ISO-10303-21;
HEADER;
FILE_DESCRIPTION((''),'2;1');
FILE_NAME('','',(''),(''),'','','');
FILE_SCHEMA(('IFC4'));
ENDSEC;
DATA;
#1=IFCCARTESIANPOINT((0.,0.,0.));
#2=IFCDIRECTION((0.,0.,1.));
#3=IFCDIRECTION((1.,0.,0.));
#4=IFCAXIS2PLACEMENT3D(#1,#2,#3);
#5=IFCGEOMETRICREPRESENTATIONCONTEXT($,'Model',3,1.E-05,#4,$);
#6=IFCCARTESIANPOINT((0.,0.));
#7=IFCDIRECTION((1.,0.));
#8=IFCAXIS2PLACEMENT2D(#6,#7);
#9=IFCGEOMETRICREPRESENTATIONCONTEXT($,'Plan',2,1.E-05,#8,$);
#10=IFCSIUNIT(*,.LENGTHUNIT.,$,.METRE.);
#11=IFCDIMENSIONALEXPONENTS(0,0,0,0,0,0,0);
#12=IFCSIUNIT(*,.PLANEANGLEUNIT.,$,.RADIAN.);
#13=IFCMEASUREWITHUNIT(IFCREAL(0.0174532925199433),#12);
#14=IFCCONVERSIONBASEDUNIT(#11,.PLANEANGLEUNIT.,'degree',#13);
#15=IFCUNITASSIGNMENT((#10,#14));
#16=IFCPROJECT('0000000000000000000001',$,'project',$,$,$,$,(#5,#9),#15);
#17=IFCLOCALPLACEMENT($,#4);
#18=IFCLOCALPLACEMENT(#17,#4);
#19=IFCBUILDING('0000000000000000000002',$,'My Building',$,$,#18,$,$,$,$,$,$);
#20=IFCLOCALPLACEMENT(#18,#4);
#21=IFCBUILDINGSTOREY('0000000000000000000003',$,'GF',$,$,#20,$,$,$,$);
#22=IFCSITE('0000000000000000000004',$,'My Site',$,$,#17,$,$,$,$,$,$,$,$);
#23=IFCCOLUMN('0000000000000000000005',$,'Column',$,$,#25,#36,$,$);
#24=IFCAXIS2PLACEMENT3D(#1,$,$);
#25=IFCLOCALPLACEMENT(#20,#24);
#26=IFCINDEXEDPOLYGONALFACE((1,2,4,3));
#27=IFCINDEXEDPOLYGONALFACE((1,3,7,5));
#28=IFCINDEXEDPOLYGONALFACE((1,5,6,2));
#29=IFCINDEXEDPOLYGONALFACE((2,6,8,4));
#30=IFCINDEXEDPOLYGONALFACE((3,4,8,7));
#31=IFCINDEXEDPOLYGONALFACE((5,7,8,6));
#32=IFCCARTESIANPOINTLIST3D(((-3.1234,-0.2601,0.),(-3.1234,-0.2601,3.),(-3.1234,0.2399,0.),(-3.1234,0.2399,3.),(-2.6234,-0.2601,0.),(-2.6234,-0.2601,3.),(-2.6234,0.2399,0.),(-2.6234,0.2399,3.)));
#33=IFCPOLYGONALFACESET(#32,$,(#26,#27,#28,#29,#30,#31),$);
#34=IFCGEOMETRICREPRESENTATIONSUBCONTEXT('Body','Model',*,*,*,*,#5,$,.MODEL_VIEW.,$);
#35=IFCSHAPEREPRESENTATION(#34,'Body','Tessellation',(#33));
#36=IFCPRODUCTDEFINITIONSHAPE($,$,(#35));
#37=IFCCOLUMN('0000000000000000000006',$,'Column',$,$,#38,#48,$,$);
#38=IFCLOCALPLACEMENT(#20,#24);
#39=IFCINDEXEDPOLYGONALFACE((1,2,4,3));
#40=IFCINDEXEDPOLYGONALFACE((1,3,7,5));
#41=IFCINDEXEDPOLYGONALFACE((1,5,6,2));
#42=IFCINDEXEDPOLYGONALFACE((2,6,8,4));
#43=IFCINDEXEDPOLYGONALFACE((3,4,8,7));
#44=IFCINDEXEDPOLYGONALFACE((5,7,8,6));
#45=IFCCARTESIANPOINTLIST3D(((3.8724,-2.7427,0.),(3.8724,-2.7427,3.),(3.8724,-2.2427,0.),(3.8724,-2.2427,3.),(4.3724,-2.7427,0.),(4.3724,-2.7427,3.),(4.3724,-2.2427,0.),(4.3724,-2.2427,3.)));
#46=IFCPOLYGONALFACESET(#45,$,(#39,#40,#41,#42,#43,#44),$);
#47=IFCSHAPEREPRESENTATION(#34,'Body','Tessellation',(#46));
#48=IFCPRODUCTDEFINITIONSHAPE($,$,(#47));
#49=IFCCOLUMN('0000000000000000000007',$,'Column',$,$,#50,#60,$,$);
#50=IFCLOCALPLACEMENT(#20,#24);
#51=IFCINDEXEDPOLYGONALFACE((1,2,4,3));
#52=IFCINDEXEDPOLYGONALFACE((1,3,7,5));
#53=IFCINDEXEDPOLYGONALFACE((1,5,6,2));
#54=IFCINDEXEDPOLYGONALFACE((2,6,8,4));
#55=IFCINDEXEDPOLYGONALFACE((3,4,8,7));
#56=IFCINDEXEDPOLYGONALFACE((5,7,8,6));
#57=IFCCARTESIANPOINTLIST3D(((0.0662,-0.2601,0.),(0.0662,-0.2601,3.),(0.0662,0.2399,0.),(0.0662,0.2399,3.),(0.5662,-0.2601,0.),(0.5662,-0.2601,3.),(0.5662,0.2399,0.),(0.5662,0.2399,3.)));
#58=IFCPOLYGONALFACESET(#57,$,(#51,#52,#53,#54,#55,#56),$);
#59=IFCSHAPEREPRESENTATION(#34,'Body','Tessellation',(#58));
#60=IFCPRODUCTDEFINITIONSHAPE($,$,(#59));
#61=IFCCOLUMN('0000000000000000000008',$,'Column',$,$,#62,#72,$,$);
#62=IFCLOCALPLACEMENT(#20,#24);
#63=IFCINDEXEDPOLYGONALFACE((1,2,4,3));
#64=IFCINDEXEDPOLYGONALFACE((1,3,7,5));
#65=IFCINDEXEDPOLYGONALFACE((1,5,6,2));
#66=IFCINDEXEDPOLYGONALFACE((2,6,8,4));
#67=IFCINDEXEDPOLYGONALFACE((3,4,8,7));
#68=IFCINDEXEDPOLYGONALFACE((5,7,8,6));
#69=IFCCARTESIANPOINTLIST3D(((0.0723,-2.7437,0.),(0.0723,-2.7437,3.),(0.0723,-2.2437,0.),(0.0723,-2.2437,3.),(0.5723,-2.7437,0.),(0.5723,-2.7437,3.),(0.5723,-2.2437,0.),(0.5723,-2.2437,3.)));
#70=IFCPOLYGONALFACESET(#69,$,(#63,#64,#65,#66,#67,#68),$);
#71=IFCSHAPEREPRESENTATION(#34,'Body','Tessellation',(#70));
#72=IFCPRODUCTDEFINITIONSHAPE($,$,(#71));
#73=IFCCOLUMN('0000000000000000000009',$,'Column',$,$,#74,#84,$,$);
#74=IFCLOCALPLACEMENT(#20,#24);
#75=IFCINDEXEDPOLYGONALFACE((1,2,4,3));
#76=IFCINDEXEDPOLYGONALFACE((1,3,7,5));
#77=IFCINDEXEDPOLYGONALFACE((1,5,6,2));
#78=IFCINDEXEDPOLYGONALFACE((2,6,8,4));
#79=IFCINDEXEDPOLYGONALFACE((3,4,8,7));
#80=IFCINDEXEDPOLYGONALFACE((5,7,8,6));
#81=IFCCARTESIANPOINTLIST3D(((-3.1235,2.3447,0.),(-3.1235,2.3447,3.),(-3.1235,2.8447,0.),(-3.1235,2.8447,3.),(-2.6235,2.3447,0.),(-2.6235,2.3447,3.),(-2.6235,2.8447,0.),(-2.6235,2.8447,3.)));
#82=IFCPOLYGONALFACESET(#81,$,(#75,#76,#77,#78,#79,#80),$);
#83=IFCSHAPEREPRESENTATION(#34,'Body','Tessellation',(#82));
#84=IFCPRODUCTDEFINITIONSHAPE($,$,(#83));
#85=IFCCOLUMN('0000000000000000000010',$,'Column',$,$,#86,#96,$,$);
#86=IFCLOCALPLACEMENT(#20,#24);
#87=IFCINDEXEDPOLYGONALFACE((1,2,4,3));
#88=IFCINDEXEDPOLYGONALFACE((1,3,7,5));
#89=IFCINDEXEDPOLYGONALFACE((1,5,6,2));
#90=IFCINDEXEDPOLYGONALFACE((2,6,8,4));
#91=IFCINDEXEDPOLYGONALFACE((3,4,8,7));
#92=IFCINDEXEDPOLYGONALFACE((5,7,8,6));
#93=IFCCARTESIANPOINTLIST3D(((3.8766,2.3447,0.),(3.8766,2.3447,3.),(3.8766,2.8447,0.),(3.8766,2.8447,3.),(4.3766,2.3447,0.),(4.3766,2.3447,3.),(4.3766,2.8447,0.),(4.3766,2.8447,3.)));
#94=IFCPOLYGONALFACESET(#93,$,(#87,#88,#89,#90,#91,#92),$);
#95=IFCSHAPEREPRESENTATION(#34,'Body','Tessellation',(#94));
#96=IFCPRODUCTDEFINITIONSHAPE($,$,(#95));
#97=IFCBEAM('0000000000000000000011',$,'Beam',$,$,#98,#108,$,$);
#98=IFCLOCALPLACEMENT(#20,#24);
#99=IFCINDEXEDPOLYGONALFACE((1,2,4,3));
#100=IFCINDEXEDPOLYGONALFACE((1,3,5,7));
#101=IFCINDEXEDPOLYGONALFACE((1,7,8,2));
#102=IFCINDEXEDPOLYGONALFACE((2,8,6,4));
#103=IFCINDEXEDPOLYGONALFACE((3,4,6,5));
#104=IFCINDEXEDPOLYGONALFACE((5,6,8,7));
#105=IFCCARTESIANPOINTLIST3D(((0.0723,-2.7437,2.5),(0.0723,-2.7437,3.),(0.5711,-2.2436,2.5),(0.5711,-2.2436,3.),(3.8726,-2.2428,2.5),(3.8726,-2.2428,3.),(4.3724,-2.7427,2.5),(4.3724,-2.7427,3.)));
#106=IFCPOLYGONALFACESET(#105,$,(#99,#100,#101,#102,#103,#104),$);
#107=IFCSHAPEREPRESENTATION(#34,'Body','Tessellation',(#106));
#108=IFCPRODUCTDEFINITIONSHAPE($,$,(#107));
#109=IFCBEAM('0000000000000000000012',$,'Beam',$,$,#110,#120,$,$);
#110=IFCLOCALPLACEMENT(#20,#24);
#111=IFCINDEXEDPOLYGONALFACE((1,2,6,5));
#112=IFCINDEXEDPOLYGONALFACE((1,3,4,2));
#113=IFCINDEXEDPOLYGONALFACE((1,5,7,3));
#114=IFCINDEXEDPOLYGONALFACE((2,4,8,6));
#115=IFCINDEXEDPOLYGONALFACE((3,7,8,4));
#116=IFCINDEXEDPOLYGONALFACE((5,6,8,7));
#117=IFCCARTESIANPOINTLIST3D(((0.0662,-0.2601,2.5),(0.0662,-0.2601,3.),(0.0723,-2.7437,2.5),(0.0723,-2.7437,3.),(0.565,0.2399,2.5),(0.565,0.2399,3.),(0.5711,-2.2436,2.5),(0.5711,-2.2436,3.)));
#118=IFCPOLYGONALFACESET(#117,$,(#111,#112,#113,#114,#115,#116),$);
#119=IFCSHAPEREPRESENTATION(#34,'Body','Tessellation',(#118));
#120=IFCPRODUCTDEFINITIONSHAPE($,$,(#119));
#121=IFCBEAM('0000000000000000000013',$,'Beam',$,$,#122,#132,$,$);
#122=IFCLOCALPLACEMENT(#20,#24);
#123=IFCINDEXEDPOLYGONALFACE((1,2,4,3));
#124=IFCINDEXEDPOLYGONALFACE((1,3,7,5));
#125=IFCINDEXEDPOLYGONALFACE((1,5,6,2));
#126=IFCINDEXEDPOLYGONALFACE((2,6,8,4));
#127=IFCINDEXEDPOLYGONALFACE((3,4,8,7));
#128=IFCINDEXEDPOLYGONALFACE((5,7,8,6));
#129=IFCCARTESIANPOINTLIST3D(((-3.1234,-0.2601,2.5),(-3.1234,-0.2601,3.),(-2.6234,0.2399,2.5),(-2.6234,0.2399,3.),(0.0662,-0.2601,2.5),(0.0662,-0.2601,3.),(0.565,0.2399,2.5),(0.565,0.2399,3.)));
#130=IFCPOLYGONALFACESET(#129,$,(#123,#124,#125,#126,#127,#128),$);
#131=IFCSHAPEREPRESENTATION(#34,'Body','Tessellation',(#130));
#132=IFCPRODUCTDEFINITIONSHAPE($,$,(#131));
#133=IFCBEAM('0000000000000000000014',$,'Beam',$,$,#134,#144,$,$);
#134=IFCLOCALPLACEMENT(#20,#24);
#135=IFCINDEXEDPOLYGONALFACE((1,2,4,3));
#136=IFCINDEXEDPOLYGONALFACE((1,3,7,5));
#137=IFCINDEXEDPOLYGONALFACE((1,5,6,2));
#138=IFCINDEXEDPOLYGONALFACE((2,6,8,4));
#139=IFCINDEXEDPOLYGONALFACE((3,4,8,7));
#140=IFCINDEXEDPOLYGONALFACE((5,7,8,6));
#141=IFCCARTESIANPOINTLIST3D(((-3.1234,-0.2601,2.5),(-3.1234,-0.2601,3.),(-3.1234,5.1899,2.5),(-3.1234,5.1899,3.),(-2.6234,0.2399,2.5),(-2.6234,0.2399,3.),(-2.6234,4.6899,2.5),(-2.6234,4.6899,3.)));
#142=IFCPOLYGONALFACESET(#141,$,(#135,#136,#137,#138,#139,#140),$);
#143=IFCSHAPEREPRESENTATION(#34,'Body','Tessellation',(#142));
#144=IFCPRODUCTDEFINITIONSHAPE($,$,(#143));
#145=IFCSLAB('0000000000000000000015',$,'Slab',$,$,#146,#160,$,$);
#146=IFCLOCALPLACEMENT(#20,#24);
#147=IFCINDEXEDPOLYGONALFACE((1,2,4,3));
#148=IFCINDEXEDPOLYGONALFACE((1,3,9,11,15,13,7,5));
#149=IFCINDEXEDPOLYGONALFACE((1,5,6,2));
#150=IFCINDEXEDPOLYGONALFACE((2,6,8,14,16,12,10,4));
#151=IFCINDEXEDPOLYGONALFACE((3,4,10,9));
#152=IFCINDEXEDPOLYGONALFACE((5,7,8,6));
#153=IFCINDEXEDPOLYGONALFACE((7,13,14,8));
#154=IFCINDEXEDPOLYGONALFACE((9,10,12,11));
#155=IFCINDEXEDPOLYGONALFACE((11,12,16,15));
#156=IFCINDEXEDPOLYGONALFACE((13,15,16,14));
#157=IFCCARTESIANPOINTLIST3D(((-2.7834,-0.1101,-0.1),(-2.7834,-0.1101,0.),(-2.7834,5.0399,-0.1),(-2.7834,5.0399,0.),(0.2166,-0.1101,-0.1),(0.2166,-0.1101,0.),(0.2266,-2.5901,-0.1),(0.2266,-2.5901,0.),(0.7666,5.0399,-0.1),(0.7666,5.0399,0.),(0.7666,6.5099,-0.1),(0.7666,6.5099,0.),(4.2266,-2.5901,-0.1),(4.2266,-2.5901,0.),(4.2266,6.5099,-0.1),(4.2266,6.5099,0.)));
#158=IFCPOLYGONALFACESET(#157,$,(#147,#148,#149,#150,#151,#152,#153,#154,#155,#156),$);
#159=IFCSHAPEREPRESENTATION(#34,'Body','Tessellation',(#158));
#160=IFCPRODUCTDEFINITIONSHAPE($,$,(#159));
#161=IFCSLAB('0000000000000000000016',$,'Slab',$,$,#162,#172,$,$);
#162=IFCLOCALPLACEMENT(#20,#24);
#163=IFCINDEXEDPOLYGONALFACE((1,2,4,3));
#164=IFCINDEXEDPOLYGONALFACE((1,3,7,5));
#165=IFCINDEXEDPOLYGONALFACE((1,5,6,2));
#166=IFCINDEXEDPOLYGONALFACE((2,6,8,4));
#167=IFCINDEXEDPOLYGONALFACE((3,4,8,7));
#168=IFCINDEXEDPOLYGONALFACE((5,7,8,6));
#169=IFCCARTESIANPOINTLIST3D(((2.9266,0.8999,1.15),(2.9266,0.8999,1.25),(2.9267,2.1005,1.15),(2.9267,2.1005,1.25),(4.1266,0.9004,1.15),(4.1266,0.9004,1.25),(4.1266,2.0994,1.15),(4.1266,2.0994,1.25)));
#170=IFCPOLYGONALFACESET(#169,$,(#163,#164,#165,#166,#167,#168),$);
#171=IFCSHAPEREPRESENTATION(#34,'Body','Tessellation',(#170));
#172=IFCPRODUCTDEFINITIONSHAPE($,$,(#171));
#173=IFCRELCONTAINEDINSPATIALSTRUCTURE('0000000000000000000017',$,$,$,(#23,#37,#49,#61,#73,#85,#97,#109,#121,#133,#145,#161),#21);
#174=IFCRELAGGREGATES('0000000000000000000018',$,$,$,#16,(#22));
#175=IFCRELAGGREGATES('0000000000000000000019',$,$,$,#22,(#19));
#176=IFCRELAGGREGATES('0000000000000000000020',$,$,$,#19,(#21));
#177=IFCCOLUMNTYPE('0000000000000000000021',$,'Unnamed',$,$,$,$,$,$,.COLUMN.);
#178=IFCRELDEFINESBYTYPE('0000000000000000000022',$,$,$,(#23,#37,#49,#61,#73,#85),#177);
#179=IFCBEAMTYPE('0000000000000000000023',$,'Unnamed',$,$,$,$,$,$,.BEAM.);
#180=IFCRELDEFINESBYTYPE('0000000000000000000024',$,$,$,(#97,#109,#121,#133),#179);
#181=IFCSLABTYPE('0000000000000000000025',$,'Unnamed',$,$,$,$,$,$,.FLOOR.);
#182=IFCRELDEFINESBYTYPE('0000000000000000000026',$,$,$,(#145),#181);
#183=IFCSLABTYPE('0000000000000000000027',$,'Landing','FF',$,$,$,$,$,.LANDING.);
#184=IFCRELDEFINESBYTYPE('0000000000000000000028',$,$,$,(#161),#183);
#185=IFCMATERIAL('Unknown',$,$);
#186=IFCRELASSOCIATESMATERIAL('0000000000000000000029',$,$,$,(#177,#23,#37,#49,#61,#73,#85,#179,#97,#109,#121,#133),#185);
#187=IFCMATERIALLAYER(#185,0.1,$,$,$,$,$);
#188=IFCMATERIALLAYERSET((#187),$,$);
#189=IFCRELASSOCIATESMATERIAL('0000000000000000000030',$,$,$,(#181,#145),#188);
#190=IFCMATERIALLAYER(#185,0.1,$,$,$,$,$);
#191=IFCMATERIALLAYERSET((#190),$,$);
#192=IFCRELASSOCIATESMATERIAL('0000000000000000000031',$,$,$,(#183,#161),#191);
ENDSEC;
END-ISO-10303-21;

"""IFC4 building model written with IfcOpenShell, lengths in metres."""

from ifc_helpers import new_model, entity, si_unit, converted_unit, frame, origin_with_axes, origin_2d_with_axis, place, context, subcontext, project, spatial, indexed_curve, rectangle, outline, extrude, clip, halfspace, material, layer, layer_set, layer_usage, material_profile, profile_set, profile_usage, type_object, element, save


model = new_model("IFC4")

# Units and contexts
model_context = context("Model", 3, precision=1e-05, world=origin_with_axes())
plan_context = context("Plan", 2, precision=1e-05, world=origin_2d_with_axis())
body_context_1 = subcontext(model_context, "Body", "Model", "MODEL_VIEW")
ifc_project = project(units=[si_unit("LENGTHUNIT", "METRE"), converted_unit("PLANEANGLEUNIT", "degree", entity("IfcReal", 0.0174532925199433), si_unit("PLANEANGLEUNIT", "RADIAN"), dimensions=[0, 0, 0, 0, 0, 0, 0])], contexts=[model_context, plan_context])

# Site, building, storey
site_placement = place(None, origin_with_axes())
site = spatial("IfcSite", under=ifc_project, at=site_placement, Name="My Site")
building_placement = place(site_placement, origin_with_axes())
building = spatial("IfcBuilding", under=site, at=building_placement, Name="My Building")
storey_placement = place(building_placement, origin_with_axes())
storey = spatial("IfcBuildingStorey", under=building, at=storey_placement, Name="GF")

# Columns
ifc_material_1 = material(Name="Unknown")
ifc_material_profile_1 = material_profile(ifc_material_1, rectangle(XDim=0.5, YDim=0.5))
ifc_profile_set_1 = profile_set([ifc_material_profile_1])
ifc_profile_usage_1 = profile_usage(ifc_profile_set_1, cardinal=5)
column_type = type_object("IfcColumnType", Name="Unnamed", PredefinedType="COLUMN", material=ifc_profile_set_1)
column_1_placement = place(storey_placement, frame((-2.8734, -0.0101, 0.0), z_axis=(0.0, 0.0, 1.0), x_axis=(1.0, 0.0, 0.0)))
element("IfcColumn", 1, at=column_1_placement, inside=storey, type_object=column_type, material=ifc_profile_usage_1, Name="Column", context=body_context_1, shape_type="SweptSolid", body=[
    extrude(rectangle(XDim=0.5, YDim=0.5), origin_with_axes(), (0.0, 0.0, 1.0), 3.0),
])
ifc_profile_usage_2 = profile_usage(ifc_profile_set_1, cardinal=5)
column_2_placement = place(storey_placement, frame((4.1224, -2.4927, 0.0), z_axis=(0.0, 0.0, 1.0), x_axis=(1.0, 0.0, 0.0)))
element("IfcColumn", 2, at=column_2_placement, inside=storey, type_object=column_type, material=ifc_profile_usage_2, Name="Column", context=body_context_1, shape_type="SweptSolid", body=[
    extrude(rectangle(XDim=0.5, YDim=0.5), origin_with_axes(), (0.0, 0.0, 1.0), 3.0),
])
ifc_profile_usage_3 = profile_usage(ifc_profile_set_1, cardinal=5)
column_3_placement = place(storey_placement, frame((0.3162, -0.0101, 0.0), z_axis=(0.0, 0.0, 1.0), x_axis=(1.0, 0.0, 0.0)))
element("IfcColumn", 3, at=column_3_placement, inside=storey, type_object=column_type, material=ifc_profile_usage_3, Name="Column", context=body_context_1, shape_type="SweptSolid", body=[
    extrude(rectangle(XDim=0.5, YDim=0.5), origin_with_axes(), (0.0, 0.0, 1.0), 3.0),
])
ifc_profile_usage_4 = profile_usage(ifc_profile_set_1, cardinal=5)
column_4_placement = place(storey_placement, frame((0.3223, -2.4937, 0.0), z_axis=(0.0, 0.0, 1.0), x_axis=(1.0, 0.0, 0.0)))
element("IfcColumn", 4, at=column_4_placement, inside=storey, type_object=column_type, material=ifc_profile_usage_4, Name="Column", context=body_context_1, shape_type="SweptSolid", body=[
    extrude(rectangle(XDim=0.5, YDim=0.5), origin_with_axes(), (0.0, 0.0, 1.0), 3.0),
])
ifc_profile_usage_5 = profile_usage(ifc_profile_set_1, cardinal=5)
column_5_placement = place(storey_placement, frame((-2.8735, 2.5947, 0.0), z_axis=(0.0, 0.0, 1.0), x_axis=(1.0, 0.0, 0.0)))
element("IfcColumn", 5, at=column_5_placement, inside=storey, type_object=column_type, material=ifc_profile_usage_5, Name="Column", context=body_context_1, shape_type="SweptSolid", body=[
    extrude(rectangle(XDim=0.5, YDim=0.5), origin_with_axes(), (0.0, 0.0, 1.0), 3.0),
])
ifc_profile_usage_6 = profile_usage(ifc_profile_set_1, cardinal=5)
column_6_placement = place(storey_placement, frame((4.1266, 2.5947, 0.0), z_axis=(0.0, 0.0, 1.0), x_axis=(1.0, 0.0, 0.0)))
element("IfcColumn", 6, at=column_6_placement, inside=storey, type_object=column_type, material=ifc_profile_usage_6, Name="Column", context=body_context_1, shape_type="SweptSolid", body=[
    extrude(rectangle(XDim=0.5, YDim=0.5), origin_with_axes(), (0.0, 0.0, 1.0), 3.0),
])

# Beams
ifc_material_profile_2 = material_profile(ifc_material_1, rectangle(XDim=0.5, YDim=0.5))
ifc_profile_set_2 = profile_set([ifc_material_profile_2])
ifc_profile_usage_7 = profile_usage(ifc_profile_set_2, cardinal=7)
beam_type = type_object("IfcBeamType", Name="Unnamed", PredefinedType="BEAM", material=ifc_profile_set_2)
beam_1_placement = place(storey_placement, frame((4.8724, -2.7426, 3.0), z_axis=(-1.0, -0.000231, 0.0), x_axis=(0.000231, -1.0, 0.0)))
element("IfcBeam", 7, at=beam_1_placement, inside=storey, type_object=beam_type, material=ifc_profile_usage_7, Name="Beam", context=body_context_1, shape_type="Clipping", body=[
    clip(clip(extrude(rectangle(XDim=0.5, YDim=0.5), frame((-0.25, -0.25, 0.0), z_axis=(0.0, 0.0, 1.0), x_axis=(1.0, 0.0, 0.0)), (0.0, 0.0, 1.0), 5.3001), halfspace(frame((0.0, -3.0, 4.8001), z_axis=(-0.706313, 0.0, 0.707899), x_axis=(0.0, 1.0, 0.0)), False)), halfspace(frame((0.0, -3.0, 0.5), z_axis=(-0.706867, 0.0, -0.707346), x_axis=(0.0, 1.0, 0.0)), False)),
])
ifc_profile_usage_8 = profile_usage(ifc_profile_set_2, cardinal=7)
beam_2_placement = place(storey_placement, frame((0.0736, -3.2437, 3.0), z_axis=(-0.002474, 0.999997, 0.0), x_axis=(-0.999997, -0.002474, 0.0)))
element("IfcBeam", 8, at=beam_2_placement, inside=storey, type_object=beam_type, material=ifc_profile_usage_8, Name="Beam", context=body_context_1, shape_type="Clipping", body=[
    clip(clip(extrude(rectangle(XDim=0.5, YDim=0.5), frame((-0.25, -0.25, 0.0), z_axis=(0.0, 0.0, 1.0), x_axis=(1.0, 0.0, 0.0)), (0.0, 0.0, 1.0), 3.9836), halfspace(frame((-0.5, -3.0, 3.4824), z_axis=(0.706232, 0.0, 0.707981), x_axis=(0.0, -1.0, 0.0)), False)), halfspace(frame((0.0, -3.0, 0.5), z_axis=(-0.706314, 0.0, -0.707899), x_axis=(0.0, 1.0, 0.0)), False)),
])
ifc_profile_usage_9 = profile_usage(ifc_profile_set_2, cardinal=7)
beam_3_placement = place(storey_placement, frame((1.0662, -0.2601, 3.0), z_axis=(-1.0, 0.0, 0.0), x_axis=(0.0, -1.0, 0.0)))
element("IfcBeam", 9, at=beam_3_placement, inside=storey, type_object=beam_type, material=ifc_profile_usage_9, Name="Beam", context=body_context_1, shape_type="Clipping", body=[
    clip(clip(extrude(rectangle(XDim=0.5, YDim=0.5), frame((-0.25, -0.25, 0.0), z_axis=(0.0, 0.0, 1.0), x_axis=(1.0, 0.0, 0.0)), (0.0, 0.0, 1.0), 4.1896), halfspace(frame((0.0, -3.0, 4.1896), z_axis=(-0.707107, 0.0, 0.707107), x_axis=(0.0, 1.0, 0.0)), False)), halfspace(frame((-0.5, -3.0, 0.5012), z_axis=(0.706232, 0.0, -0.707981), x_axis=(0.0, -1.0, 0.0)), False)),
])
ifc_profile_usage_10 = profile_usage(ifc_profile_set_2, cardinal=7)
beam_4_placement = place(storey_placement, frame((-3.1234, -0.2601, 3.0), z_axis=(0.0, 1.0, 0.0), x_axis=(-1.0, 0.0, 0.0)))
element("IfcBeam", 10, at=beam_4_placement, inside=storey, type_object=beam_type, material=ifc_profile_usage_10, Name="Beam", context=body_context_1, shape_type="Clipping", body=[
    clip(clip(extrude(rectangle(XDim=0.5, YDim=0.5), frame((-0.25, -0.25, 0.0), z_axis=(0.0, 0.0, 1.0), x_axis=(1.0, 0.0, 0.0)), (0.0, 0.0, 1.0), 5.45), halfspace(frame((0.0, -3.0, 5.45), z_axis=(-0.707107, 0.0, 0.707107), x_axis=(0.0, 1.0, 0.0)), False)), halfspace(frame((0.0, -3.0, 0.0), z_axis=(-0.707107, 0.0, -0.707107), x_axis=(0.0, 1.0, 0.0)), False)),
])

# Slabs
ifc_layer_1 = layer(ifc_material_1, 0.1)
ifc_layer_set_1 = layer_set([ifc_layer_1])
ifc_layer_usage_1 = layer_usage(ifc_layer_set_1, "AXIS3", "POSITIVE", -0.1)
slab_type_1 = type_object("IfcSlabType", Name="Unnamed", PredefinedType="FLOOR", material=ifc_layer_set_1)
slab_1_placement = place(storey_placement, frame((4.2266, -2.5901, 0.0), z_axis=(0.0, 0.0, 1.0), x_axis=(1.0, 0.0, 0.0)))
element("IfcSlab", 11, at=slab_1_placement, inside=storey, type_object=slab_type_1, material=ifc_layer_usage_1, Name="Slab", context=body_context_1, shape_type="SweptSolid", body=[
    extrude(outline(indexed_curve([(0.0, 0.0), (0.0, 9.1), (-3.46, 9.1), (-3.46, 7.63), (-7.01, 7.63), (-7.01, 2.48), (-4.01, 2.48), (-4.0, 0.0), (0.0, 0.0)])), frame((0.0, 0.0, -0.1), z_axis=(0.0, 0.0, 1.0), x_axis=(1.0, 0.0, 0.0)), (0.0, 0.0, 1.0), 0.1),
])
ifc_layer_2 = layer(ifc_material_1, 0.1)
ifc_layer_set_2 = layer_set([ifc_layer_2])
ifc_layer_usage_2 = layer_usage(ifc_layer_set_2, "AXIS3", "POSITIVE", -0.1)
slab_type_2 = type_object("IfcSlabType", Name="Landing", Description="FF", PredefinedType="LANDING", material=ifc_layer_set_2)
slab_2_placement = place(storey_placement, frame((2.9266, 0.8999, 1.25), z_axis=(0.0, 0.0, 1.0), x_axis=(1.0, 0.0, 0.0)))
element("IfcSlab", 12, at=slab_2_placement, inside=storey, type_object=slab_type_2, material=ifc_layer_usage_2, Name="Slab", context=body_context_1, shape_type="SweptSolid", body=[
    extrude(outline(indexed_curve([(0.0, 0.0), (1.2, 0.0005), (1.2, 1.1995), (0.0001, 1.2006), (0.0, 0.0)])), frame((0.0, 0.0, -0.1), z_axis=(0.0, 0.0, 1.0), x_axis=(1.0, 0.0, 0.0)), (0.0, 0.0, 1.0), 0.1),
])

save(model, "model.ifc")
